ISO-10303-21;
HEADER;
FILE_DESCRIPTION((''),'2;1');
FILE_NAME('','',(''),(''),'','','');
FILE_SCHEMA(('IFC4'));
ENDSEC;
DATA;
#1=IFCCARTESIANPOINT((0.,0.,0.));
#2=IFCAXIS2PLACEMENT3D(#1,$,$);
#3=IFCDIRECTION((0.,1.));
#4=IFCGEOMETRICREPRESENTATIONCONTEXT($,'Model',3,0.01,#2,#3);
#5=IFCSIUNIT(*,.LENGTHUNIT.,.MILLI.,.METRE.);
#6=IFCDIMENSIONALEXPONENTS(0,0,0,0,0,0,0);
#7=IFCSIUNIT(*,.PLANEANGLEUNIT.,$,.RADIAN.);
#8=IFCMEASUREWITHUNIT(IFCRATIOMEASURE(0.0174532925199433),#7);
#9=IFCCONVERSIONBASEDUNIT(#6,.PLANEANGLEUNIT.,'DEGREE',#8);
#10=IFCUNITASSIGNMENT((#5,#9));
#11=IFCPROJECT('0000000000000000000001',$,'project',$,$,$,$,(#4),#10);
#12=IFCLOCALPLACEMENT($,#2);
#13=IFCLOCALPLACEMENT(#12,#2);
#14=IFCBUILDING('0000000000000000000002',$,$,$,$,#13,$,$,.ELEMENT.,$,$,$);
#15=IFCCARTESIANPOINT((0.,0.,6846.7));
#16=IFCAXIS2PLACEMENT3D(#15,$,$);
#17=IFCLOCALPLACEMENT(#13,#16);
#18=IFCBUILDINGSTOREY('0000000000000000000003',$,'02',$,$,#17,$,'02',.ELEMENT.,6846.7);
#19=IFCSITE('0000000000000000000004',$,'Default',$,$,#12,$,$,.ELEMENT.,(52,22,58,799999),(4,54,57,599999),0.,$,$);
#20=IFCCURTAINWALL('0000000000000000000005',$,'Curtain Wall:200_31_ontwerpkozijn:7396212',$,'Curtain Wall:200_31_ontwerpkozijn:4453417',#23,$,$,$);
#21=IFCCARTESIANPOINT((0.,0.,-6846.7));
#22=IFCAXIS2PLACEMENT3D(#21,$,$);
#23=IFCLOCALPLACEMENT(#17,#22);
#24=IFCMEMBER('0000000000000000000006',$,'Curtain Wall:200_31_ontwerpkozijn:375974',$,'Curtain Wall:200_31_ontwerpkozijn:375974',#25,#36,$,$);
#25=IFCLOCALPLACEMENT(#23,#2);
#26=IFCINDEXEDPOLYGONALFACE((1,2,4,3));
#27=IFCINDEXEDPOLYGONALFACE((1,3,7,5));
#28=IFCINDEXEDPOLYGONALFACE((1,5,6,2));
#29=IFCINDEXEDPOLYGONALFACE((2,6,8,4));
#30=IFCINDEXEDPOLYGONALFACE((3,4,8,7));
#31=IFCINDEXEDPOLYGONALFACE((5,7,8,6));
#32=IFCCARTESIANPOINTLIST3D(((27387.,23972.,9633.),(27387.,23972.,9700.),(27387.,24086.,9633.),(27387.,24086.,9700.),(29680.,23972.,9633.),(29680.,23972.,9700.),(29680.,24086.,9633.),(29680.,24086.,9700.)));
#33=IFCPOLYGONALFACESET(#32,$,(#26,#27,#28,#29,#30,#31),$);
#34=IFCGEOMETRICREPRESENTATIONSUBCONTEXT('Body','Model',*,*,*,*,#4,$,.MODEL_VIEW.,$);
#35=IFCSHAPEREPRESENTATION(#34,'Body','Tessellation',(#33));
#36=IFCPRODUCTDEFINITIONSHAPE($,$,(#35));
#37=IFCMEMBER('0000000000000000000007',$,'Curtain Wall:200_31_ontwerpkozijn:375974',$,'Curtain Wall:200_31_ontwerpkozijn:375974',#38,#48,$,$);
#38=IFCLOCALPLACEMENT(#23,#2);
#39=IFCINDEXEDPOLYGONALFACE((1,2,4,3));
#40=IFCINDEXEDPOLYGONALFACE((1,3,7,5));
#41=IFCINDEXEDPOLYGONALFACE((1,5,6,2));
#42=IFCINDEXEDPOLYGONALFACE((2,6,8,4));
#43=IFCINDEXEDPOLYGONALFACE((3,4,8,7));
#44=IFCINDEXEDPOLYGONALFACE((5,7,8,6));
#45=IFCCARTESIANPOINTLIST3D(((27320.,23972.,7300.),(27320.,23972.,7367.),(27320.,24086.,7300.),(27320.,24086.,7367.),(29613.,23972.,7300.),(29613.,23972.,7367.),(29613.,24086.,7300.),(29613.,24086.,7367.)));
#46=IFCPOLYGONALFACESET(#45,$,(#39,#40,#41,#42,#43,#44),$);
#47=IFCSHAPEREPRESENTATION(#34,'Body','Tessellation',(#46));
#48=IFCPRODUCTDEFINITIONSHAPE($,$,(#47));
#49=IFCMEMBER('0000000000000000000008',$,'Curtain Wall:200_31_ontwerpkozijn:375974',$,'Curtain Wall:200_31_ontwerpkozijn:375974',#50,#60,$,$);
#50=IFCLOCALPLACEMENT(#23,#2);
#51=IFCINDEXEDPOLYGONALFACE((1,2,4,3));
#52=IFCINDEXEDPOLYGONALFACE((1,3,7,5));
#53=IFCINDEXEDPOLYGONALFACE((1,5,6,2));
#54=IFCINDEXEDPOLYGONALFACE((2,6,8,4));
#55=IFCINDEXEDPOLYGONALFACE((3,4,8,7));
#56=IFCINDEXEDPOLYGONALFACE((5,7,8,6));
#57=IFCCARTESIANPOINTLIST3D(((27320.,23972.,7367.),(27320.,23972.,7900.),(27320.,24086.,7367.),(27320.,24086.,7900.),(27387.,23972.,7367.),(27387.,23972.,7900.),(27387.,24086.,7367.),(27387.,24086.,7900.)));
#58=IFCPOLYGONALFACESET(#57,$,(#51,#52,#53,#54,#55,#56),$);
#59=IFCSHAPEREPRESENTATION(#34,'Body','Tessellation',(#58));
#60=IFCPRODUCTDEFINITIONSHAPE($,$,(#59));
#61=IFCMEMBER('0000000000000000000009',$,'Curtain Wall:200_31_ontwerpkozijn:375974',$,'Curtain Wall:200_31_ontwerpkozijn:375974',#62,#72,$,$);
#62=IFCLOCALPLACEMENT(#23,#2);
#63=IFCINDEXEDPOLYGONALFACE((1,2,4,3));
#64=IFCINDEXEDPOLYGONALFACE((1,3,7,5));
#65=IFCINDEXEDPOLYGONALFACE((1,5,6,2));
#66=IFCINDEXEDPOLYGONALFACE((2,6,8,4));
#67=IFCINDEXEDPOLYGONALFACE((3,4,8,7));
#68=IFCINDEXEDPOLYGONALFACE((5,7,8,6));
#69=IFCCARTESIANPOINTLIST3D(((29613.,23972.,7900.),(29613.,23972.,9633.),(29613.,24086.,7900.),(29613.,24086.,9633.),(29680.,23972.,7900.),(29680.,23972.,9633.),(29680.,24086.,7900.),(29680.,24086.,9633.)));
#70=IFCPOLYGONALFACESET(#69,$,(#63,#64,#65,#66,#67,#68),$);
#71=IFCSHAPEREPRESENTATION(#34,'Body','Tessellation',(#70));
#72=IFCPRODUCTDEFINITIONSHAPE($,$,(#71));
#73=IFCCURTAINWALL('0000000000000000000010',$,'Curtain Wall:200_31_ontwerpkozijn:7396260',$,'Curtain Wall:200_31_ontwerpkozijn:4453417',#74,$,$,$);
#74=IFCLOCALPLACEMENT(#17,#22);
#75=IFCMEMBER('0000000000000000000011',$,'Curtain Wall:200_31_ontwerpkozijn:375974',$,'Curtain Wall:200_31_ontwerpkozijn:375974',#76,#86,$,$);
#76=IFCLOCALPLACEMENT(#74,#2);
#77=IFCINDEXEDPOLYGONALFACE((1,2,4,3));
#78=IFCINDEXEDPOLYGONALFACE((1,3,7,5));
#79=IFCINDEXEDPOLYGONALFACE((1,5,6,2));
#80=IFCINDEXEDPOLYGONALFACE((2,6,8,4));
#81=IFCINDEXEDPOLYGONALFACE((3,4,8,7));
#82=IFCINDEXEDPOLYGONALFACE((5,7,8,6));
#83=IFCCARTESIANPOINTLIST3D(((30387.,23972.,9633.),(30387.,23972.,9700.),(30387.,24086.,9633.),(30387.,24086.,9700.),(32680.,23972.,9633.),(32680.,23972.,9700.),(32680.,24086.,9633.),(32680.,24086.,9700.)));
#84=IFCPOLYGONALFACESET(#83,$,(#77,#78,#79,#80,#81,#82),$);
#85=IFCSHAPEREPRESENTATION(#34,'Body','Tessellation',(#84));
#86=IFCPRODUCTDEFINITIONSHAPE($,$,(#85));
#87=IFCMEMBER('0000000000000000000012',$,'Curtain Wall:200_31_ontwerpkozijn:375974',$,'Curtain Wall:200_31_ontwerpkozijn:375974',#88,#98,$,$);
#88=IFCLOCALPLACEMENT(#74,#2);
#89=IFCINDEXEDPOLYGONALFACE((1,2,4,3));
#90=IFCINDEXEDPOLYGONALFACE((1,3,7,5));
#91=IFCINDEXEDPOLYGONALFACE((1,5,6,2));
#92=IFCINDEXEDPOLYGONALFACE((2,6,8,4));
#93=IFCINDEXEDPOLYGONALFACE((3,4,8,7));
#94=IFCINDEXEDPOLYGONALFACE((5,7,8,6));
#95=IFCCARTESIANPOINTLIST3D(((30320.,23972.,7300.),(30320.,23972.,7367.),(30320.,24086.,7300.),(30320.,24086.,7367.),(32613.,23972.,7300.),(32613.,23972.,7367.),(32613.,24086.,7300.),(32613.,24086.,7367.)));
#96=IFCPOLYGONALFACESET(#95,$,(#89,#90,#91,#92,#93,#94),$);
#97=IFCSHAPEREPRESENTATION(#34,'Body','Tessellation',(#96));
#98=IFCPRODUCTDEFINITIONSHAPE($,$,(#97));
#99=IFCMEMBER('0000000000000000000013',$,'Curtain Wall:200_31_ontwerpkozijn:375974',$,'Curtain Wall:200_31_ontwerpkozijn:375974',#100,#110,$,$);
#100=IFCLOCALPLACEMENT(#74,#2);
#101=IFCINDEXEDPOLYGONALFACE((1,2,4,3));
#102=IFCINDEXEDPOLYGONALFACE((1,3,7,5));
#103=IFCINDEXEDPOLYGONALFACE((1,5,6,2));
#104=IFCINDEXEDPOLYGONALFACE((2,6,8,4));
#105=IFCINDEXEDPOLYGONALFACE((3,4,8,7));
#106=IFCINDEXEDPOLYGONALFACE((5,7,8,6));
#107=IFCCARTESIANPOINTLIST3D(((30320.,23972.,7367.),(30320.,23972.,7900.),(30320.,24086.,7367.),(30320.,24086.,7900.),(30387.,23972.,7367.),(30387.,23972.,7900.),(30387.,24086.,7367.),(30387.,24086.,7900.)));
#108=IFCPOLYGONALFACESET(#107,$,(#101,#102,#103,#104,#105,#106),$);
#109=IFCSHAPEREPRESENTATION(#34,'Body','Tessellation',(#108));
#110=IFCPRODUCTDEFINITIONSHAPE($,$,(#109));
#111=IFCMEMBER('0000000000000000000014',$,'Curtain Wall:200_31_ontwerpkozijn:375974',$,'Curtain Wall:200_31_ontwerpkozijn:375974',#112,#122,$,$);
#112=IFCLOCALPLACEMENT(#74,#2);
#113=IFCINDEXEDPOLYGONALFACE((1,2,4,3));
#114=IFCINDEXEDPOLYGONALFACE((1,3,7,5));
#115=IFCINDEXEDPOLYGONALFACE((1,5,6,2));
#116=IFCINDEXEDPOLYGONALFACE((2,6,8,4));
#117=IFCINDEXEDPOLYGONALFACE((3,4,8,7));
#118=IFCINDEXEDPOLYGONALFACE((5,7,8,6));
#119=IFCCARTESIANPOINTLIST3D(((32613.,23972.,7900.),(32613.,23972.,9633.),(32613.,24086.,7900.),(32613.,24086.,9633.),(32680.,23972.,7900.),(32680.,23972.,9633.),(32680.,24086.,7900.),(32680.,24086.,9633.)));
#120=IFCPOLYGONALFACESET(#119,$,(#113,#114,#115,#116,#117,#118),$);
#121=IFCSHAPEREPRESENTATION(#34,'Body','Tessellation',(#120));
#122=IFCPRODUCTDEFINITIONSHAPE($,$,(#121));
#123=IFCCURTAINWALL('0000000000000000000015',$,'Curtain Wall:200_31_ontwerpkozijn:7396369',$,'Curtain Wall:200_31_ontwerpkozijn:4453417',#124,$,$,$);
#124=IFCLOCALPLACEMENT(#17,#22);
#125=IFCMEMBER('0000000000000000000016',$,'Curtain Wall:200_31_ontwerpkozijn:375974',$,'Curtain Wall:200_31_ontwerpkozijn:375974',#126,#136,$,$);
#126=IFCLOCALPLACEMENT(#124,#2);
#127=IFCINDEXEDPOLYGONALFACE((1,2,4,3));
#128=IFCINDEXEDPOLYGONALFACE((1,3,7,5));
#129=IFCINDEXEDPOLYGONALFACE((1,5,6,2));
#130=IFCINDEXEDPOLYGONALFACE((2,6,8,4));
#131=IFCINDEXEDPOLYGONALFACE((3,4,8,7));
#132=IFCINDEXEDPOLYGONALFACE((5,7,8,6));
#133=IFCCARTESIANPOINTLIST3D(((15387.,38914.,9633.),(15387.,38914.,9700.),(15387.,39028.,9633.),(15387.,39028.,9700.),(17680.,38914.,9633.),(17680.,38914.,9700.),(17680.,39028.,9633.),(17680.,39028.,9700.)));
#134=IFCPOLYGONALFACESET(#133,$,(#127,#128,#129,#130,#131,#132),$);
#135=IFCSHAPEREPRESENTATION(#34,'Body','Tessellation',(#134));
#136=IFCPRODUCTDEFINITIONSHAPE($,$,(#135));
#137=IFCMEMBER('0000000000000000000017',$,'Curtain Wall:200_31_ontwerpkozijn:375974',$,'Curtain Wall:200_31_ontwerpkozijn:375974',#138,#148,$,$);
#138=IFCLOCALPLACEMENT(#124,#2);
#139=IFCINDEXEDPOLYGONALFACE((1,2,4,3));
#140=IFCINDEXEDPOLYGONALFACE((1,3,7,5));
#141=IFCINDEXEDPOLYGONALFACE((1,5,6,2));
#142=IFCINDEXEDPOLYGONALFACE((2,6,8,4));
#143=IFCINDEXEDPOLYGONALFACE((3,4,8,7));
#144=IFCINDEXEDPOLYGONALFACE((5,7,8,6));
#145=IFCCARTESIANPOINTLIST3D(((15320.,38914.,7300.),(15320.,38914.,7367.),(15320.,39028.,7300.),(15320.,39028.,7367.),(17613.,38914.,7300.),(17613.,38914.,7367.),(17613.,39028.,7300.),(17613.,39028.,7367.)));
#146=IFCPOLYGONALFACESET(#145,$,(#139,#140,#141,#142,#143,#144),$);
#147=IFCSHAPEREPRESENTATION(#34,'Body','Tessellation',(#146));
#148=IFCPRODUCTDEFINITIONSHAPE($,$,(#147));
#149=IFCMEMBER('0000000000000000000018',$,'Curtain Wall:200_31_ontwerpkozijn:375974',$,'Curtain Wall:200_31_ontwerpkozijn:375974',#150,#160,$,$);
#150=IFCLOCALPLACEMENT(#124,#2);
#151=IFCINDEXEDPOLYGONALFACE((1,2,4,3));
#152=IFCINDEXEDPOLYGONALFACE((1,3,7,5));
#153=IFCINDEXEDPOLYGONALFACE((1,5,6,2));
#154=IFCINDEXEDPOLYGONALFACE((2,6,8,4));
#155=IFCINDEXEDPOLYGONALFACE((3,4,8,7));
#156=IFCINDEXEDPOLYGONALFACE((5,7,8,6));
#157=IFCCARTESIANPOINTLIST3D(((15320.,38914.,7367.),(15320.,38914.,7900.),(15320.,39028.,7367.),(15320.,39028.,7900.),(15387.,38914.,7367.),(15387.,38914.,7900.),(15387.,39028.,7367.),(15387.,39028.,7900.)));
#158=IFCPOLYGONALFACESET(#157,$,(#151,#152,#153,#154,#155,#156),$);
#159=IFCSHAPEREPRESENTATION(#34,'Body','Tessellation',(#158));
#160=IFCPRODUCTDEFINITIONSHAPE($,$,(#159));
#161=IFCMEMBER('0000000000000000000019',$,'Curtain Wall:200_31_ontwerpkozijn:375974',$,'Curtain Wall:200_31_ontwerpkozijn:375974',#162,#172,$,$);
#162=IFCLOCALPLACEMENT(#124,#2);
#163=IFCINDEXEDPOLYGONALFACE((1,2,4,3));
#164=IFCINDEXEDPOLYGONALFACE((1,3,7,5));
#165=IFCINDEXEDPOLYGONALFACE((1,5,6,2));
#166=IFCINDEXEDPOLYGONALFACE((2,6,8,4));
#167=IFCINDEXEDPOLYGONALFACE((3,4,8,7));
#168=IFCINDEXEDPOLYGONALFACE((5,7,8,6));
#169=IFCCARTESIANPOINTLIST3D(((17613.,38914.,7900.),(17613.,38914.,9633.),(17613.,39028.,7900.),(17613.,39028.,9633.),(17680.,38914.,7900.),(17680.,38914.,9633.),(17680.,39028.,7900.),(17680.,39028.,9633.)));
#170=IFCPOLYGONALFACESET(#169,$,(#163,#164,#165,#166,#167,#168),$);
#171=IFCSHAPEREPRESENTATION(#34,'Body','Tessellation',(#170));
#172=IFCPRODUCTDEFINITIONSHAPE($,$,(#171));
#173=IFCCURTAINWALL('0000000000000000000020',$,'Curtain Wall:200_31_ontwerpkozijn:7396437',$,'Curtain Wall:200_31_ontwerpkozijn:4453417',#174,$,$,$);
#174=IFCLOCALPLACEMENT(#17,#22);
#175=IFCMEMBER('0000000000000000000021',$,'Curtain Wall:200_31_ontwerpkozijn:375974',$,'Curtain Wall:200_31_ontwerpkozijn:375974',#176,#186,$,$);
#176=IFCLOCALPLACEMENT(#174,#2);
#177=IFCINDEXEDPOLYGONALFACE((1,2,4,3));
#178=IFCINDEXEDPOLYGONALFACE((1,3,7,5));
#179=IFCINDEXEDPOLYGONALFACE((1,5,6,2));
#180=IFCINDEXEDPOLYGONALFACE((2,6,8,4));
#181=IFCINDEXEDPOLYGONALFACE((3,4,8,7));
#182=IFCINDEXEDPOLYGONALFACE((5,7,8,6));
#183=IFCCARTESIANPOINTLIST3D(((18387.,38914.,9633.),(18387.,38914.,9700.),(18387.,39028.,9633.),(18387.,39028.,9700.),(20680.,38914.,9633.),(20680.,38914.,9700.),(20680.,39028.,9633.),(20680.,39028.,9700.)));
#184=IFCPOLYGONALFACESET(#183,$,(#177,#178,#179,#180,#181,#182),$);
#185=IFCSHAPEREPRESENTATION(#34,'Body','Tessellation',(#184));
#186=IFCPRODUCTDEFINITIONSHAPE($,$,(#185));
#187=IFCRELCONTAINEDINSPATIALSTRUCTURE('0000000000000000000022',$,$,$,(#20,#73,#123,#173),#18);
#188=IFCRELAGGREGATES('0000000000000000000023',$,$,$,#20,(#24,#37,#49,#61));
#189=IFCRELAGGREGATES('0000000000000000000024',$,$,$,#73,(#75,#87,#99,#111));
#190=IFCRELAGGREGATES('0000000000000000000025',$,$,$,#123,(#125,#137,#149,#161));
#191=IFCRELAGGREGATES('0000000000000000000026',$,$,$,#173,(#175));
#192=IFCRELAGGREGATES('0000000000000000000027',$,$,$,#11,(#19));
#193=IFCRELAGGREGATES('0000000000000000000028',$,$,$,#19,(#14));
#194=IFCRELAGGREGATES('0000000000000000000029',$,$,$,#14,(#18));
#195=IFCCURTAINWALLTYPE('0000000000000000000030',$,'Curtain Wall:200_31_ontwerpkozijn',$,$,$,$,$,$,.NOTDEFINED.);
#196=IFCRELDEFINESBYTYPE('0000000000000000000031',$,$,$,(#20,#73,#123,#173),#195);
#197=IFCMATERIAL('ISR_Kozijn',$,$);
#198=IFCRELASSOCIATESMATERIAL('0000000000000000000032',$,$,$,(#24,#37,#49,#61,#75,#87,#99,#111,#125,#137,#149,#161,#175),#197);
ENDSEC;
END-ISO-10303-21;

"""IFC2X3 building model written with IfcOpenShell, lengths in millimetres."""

from ifc_helpers import new_model, entity, si_unit, converted_unit, direction, frame, frame_2d, origin, origin_2d_with_axis, place, context, subcontext, project, spatial, rectangle, extrude, material, type_object, element, aggregate, save


model = new_model("IFC2X3")

# Units and contexts
model_context = context("Model", 3, precision=0.01, world=origin(), true_north=direction((0.0, 1.0)))
body_context = subcontext(model_context, "Body", "Model", "MODEL_VIEW")
ifc_project = project(units=[si_unit("LENGTHUNIT", "METRE", prefix="MILLI"), converted_unit("PLANEANGLEUNIT", "DEGREE", entity("IfcRatioMeasure", 0.0174532925199433), si_unit("PLANEANGLEUNIT", "RADIAN"), dimensions=[0, 0, 0, 0, 0, 0, 0])], contexts=[model_context])

# Site, building, storey
site_placement = place(None, origin())
site = spatial("IfcSite", under=ifc_project, at=site_placement, Name="Default", CompositionType="ELEMENT", RefLatitude=(52, 22, 58, 799999), RefLongitude=(4, 54, 57, 599999), RefElevation=0.0)
building_placement = place(site_placement, origin())
building = spatial("IfcBuilding", under=site, at=building_placement, CompositionType="ELEMENT")
storey_placement = place(building_placement, frame((0.0, 0.0, 6846.7)))
storey = spatial("IfcBuildingStorey", under=building, at=storey_placement, Name="02", LongName="02", CompositionType="ELEMENT", Elevation=6846.7)

# Curtain walls, members
curtain_wall_type = type_object("IfcCurtainWallType", Name="Curtain Wall:200_31_ontwerpkozijn", PredefinedType="NOTDEFINED")
ifc_material = material(Name="ISR_Kozijn")
curtain_wall_1_placement = place(storey_placement, frame((0.0, 0.0, -6846.7)))
curtain_wall_1 = element("IfcCurtainWall", 1, at=curtain_wall_1_placement, inside=storey, type_object=curtain_wall_type, Name="Curtain Wall:200_31_ontwerpkozijn:7396212", ObjectType="Curtain Wall:200_31_ontwerpkozijn:4453417")
member_1_placement = place(curtain_wall_1_placement, origin())
member_1 = element("IfcMember", 2, at=member_1_placement, material=ifc_material, Name="Curtain Wall:200_31_ontwerpkozijn:375974", ObjectType="Curtain Wall:200_31_ontwerpkozijn:375974", context=body_context, shape_type="SweptSolid", body=[
    extrude(rectangle(XDim=67.0, YDim=114.0, at=frame_2d((0.0, 0.0), x_axis=(1.0, 0.0))), frame((27387.0, 24029.0, 9666.5), z_axis=(1.0, 0.0, 0.0), x_axis=(0.0, 0.0, -1.0)), (0.0, 0.0, 1.0), 2293.0),
])
member_2_placement = place(curtain_wall_1_placement, origin())
member_2 = element("IfcMember", 3, at=member_2_placement, material=ifc_material, Name="Curtain Wall:200_31_ontwerpkozijn:375974", ObjectType="Curtain Wall:200_31_ontwerpkozijn:375974", context=body_context, shape_type="SweptSolid", body=[
    extrude(rectangle(XDim=67.0, YDim=114.0, at=frame_2d((0.0, 0.0), x_axis=(1.0, 0.0))), frame((29613.0, 24029.0, 7333.5), z_axis=(-1.0, 0.0, 0.0), x_axis=(0.0, 0.0, -1.0)), (0.0, 0.0, 1.0), 2293.0),
])
member_3_placement = place(curtain_wall_1_placement, origin())
member_3 = element("IfcMember", 4, at=member_3_placement, material=ifc_material, Name="Curtain Wall:200_31_ontwerpkozijn:375974", ObjectType="Curtain Wall:200_31_ontwerpkozijn:375974", context=body_context, shape_type="SweptSolid", body=[
    extrude(rectangle(XDim=67.0, YDim=114.0, at=origin_2d_with_axis()), frame((27353.5, 24029.0, 7367.0), z_axis=(0.0, 0.0, 1.0), x_axis=(-1.0, 0.0, 0.0)), (0.0, 0.0, 1.0), 533.0),
])
member_4_placement = place(curtain_wall_1_placement, origin())
member_4 = element("IfcMember", 5, at=member_4_placement, material=ifc_material, Name="Curtain Wall:200_31_ontwerpkozijn:375974", ObjectType="Curtain Wall:200_31_ontwerpkozijn:375974", context=body_context, shape_type="SweptSolid", body=[
    extrude(rectangle(XDim=67.0, YDim=114.0, at=origin_2d_with_axis()), frame((29646.5, 24029.0, 9633.0), z_axis=(0.0, 0.0, -1.0), x_axis=(-1.0, 0.0, 0.0)), (0.0, 0.0, 1.0), 1733.0),
])
aggregate(curtain_wall_1, [member_1, member_2, member_3, member_4])
curtain_wall_2_placement = place(storey_placement, frame((0.0, 0.0, -6846.7)))
curtain_wall_2 = element("IfcCurtainWall", 6, at=curtain_wall_2_placement, inside=storey, type_object=curtain_wall_type, Name="Curtain Wall:200_31_ontwerpkozijn:7396260", ObjectType="Curtain Wall:200_31_ontwerpkozijn:4453417")
member_5_placement = place(curtain_wall_2_placement, origin())
member_5 = element("IfcMember", 7, at=member_5_placement, material=ifc_material, Name="Curtain Wall:200_31_ontwerpkozijn:375974", ObjectType="Curtain Wall:200_31_ontwerpkozijn:375974", context=body_context, shape_type="SweptSolid", body=[
    extrude(rectangle(XDim=67.0, YDim=114.0, at=frame_2d((0.0, 0.0), x_axis=(1.0, 0.0))), frame((30387.0, 24029.0, 9666.5), z_axis=(1.0, 0.0, 0.0), x_axis=(0.0, 0.0, -1.0)), (0.0, 0.0, 1.0), 2293.0),
])
member_6_placement = place(curtain_wall_2_placement, origin())
member_6 = element("IfcMember", 8, at=member_6_placement, material=ifc_material, Name="Curtain Wall:200_31_ontwerpkozijn:375974", ObjectType="Curtain Wall:200_31_ontwerpkozijn:375974", context=body_context, shape_type="SweptSolid", body=[
    extrude(rectangle(XDim=67.0, YDim=114.0, at=frame_2d((0.0, 0.0), x_axis=(1.0, 0.0))), frame((32613.0, 24029.0, 7333.5), z_axis=(-1.0, 0.0, 0.0), x_axis=(0.0, 0.0, -1.0)), (0.0, 0.0, 1.0), 2293.0),
])
member_7_placement = place(curtain_wall_2_placement, origin())
member_7 = element("IfcMember", 9, at=member_7_placement, material=ifc_material, Name="Curtain Wall:200_31_ontwerpkozijn:375974", ObjectType="Curtain Wall:200_31_ontwerpkozijn:375974", context=body_context, shape_type="SweptSolid", body=[
    extrude(rectangle(XDim=67.0, YDim=114.0, at=origin_2d_with_axis()), frame((30353.5, 24029.0, 7367.0), z_axis=(0.0, 0.0, 1.0), x_axis=(-1.0, 0.0, 0.0)), (0.0, 0.0, 1.0), 533.0),
])
member_8_placement = place(curtain_wall_2_placement, origin())
member_8 = element("IfcMember", 10, at=member_8_placement, material=ifc_material, Name="Curtain Wall:200_31_ontwerpkozijn:375974", ObjectType="Curtain Wall:200_31_ontwerpkozijn:375974", context=body_context, shape_type="SweptSolid", body=[
    extrude(rectangle(XDim=67.0, YDim=114.0, at=origin_2d_with_axis()), frame((32646.5, 24029.0, 9633.0), z_axis=(0.0, 0.0, -1.0), x_axis=(-1.0, 0.0, 0.0)), (0.0, 0.0, 1.0), 1733.0),
])
aggregate(curtain_wall_2, [member_5, member_6, member_7, member_8])
curtain_wall_3_placement = place(storey_placement, frame((0.0, 0.0, -6846.7)))
curtain_wall_3 = element("IfcCurtainWall", 11, at=curtain_wall_3_placement, inside=storey, type_object=curtain_wall_type, Name="Curtain Wall:200_31_ontwerpkozijn:7396369", ObjectType="Curtain Wall:200_31_ontwerpkozijn:4453417")
member_9_placement = place(curtain_wall_3_placement, origin())
member_9 = element("IfcMember", 12, at=member_9_placement, material=ifc_material, Name="Curtain Wall:200_31_ontwerpkozijn:375974", ObjectType="Curtain Wall:200_31_ontwerpkozijn:375974", context=body_context, shape_type="SweptSolid", body=[
    extrude(rectangle(XDim=67.0, YDim=114.0, at=frame_2d((0.0, 0.0), x_axis=(1.0, 0.0))), frame((15387.0, 38971.0, 9666.5), z_axis=(1.0, 0.0, 0.0), x_axis=(0.0, 0.0, -1.0)), (0.0, 0.0, 1.0), 2293.0),
])
member_10_placement = place(curtain_wall_3_placement, origin())
member_10 = element("IfcMember", 13, at=member_10_placement, material=ifc_material, Name="Curtain Wall:200_31_ontwerpkozijn:375974", ObjectType="Curtain Wall:200_31_ontwerpkozijn:375974", context=body_context, shape_type="SweptSolid", body=[
    extrude(rectangle(XDim=67.0, YDim=114.0, at=frame_2d((0.0, 0.0), x_axis=(1.0, 0.0))), frame((17613.0, 38971.0, 7333.5), z_axis=(-1.0, 0.0, 0.0), x_axis=(0.0, 0.0, -1.0)), (0.0, 0.0, 1.0), 2293.0),
])
member_11_placement = place(curtain_wall_3_placement, origin())
member_11 = element("IfcMember", 14, at=member_11_placement, material=ifc_material, Name="Curtain Wall:200_31_ontwerpkozijn:375974", ObjectType="Curtain Wall:200_31_ontwerpkozijn:375974", context=body_context, shape_type="SweptSolid", body=[
    extrude(rectangle(XDim=67.0, YDim=114.0, at=frame_2d((0.0, 0.0), x_axis=(1.0, 0.0))), frame((15353.5, 38971.0, 7367.0), z_axis=(0.0, 0.0, 1.0), x_axis=(-1.0, 0.0, 0.0)), (0.0, 0.0, 1.0), 533.0),
])
member_12_placement = place(curtain_wall_3_placement, origin())
member_12 = element("IfcMember", 15, at=member_12_placement, material=ifc_material, Name="Curtain Wall:200_31_ontwerpkozijn:375974", ObjectType="Curtain Wall:200_31_ontwerpkozijn:375974", context=body_context, shape_type="SweptSolid", body=[
    extrude(rectangle(XDim=67.0, YDim=114.0, at=frame_2d((0.0, 0.0), x_axis=(1.0, 0.0))), frame((17646.5, 38971.0, 9633.0), z_axis=(0.0, 0.0, -1.0), x_axis=(-1.0, 0.0, 0.0)), (0.0, 0.0, 1.0), 1733.0),
])
aggregate(curtain_wall_3, [member_9, member_10, member_11, member_12])
curtain_wall_4_placement = place(storey_placement, frame((0.0, 0.0, -6846.7)))
curtain_wall_4 = element("IfcCurtainWall", 16, at=curtain_wall_4_placement, inside=storey, type_object=curtain_wall_type, Name="Curtain Wall:200_31_ontwerpkozijn:7396437", ObjectType="Curtain Wall:200_31_ontwerpkozijn:4453417")
member_13_placement = place(curtain_wall_4_placement, origin())
member_13 = element("IfcMember", 17, at=member_13_placement, material=ifc_material, Name="Curtain Wall:200_31_ontwerpkozijn:375974", ObjectType="Curtain Wall:200_31_ontwerpkozijn:375974", context=body_context, shape_type="SweptSolid", body=[
    extrude(rectangle(XDim=67.0, YDim=114.0, at=frame_2d((0.0, 0.0), x_axis=(1.0, 0.0))), frame((18387.0, 38971.0, 9666.5), z_axis=(1.0, 0.0, 0.0), x_axis=(0.0, 0.0, -1.0)), (0.0, 0.0, 1.0), 2293.0),
])
aggregate(curtain_wall_4, [member_13])

save(model, "model.ifc")
